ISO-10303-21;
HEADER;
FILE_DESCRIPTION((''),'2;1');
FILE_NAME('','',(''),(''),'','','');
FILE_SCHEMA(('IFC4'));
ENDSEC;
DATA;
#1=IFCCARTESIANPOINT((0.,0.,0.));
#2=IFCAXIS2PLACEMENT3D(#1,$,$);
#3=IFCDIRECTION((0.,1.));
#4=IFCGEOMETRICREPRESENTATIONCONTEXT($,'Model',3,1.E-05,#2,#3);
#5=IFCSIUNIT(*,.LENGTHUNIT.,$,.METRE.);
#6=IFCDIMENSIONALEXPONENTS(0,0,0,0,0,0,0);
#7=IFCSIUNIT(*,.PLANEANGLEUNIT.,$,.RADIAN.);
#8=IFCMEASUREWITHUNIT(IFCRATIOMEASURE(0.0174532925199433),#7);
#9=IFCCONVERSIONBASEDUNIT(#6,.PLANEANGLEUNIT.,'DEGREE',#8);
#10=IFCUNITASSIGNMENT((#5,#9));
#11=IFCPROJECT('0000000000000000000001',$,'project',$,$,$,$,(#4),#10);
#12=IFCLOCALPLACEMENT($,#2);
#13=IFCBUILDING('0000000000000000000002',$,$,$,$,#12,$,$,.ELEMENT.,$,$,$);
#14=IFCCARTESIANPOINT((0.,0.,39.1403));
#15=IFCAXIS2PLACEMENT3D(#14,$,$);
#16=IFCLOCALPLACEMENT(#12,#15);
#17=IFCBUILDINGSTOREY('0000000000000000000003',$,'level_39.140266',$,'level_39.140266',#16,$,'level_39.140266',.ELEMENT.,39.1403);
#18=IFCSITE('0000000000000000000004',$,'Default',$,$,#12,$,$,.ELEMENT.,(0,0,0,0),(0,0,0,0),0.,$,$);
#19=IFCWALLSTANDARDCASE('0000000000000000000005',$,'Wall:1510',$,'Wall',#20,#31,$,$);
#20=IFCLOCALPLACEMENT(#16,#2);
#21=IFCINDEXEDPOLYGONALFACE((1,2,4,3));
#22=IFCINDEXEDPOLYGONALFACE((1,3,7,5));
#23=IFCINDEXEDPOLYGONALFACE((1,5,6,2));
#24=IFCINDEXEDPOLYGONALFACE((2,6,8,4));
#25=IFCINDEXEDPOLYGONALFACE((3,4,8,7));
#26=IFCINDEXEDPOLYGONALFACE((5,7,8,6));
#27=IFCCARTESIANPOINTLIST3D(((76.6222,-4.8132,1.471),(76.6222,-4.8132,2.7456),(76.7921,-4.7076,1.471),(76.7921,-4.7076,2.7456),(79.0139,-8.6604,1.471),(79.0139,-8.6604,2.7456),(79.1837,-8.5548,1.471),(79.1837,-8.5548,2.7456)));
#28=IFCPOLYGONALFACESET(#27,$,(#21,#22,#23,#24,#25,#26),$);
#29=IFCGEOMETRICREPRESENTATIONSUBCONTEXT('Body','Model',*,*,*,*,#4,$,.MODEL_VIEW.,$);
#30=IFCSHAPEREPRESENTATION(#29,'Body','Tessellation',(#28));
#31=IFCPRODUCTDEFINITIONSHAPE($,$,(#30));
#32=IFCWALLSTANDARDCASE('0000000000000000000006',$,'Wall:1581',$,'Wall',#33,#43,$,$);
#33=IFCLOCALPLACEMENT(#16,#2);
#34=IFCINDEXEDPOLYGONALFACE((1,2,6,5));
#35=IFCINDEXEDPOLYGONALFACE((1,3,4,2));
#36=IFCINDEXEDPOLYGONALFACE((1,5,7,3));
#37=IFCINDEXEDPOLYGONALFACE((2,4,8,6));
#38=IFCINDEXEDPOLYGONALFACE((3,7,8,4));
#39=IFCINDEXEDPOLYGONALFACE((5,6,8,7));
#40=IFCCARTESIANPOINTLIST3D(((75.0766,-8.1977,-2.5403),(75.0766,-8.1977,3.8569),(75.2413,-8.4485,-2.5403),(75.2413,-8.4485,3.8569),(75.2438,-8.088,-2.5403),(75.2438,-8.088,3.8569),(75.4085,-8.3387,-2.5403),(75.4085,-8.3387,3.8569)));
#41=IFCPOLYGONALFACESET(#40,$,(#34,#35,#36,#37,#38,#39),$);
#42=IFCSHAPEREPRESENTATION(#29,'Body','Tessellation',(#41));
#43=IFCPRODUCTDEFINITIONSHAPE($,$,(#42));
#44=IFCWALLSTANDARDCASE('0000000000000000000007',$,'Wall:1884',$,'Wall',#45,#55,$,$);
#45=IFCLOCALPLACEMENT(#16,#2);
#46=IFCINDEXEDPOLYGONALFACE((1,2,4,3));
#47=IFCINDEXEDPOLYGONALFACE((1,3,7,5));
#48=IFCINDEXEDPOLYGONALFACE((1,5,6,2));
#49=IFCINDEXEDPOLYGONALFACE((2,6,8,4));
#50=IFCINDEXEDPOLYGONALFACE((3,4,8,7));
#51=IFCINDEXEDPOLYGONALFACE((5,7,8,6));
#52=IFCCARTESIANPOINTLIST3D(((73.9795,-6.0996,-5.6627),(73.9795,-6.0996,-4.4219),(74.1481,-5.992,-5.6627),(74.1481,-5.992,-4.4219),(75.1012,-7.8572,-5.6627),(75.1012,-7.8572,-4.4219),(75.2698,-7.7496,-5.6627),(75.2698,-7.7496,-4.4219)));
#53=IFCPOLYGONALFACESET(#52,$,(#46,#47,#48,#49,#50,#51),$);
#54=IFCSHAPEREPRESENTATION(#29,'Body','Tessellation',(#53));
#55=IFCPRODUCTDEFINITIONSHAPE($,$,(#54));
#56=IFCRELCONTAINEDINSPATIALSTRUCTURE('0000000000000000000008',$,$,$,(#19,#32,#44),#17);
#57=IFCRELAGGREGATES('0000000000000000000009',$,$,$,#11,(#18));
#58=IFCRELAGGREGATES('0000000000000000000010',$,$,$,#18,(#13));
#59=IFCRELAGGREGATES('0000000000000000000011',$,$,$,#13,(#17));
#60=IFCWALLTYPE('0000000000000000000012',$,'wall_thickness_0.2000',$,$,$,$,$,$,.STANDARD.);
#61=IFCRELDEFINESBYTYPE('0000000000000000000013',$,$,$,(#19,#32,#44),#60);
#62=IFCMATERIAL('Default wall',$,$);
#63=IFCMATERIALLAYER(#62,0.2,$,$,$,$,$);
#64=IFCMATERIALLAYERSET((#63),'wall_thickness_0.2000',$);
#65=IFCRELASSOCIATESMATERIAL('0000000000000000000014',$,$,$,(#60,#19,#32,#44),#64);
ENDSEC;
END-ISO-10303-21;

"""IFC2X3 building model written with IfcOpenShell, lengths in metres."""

from ifc_helpers import new_model, entity, si_unit, converted_unit, direction, frame, origin, place, context, subcontext, project, spatial, polyline, outline, extrude, material, layer, layer_set, layer_usage, type_object, element, save


model = new_model("IFC2X3")

# Units and contexts
model_context = context("Model", 3, precision=1e-05, world=origin(), true_north=direction((0.0, 1.0)))
body_context = subcontext(model_context, "Body", "Model", "MODEL_VIEW")
ifc_project = project(units=[si_unit("LENGTHUNIT", "METRE"), converted_unit("PLANEANGLEUNIT", "DEGREE", entity("IfcRatioMeasure", 0.0174532925199433), si_unit("PLANEANGLEUNIT", "RADIAN"), dimensions=[0, 0, 0, 0, 0, 0, 0])], contexts=[model_context])

# Site, building, storey
placement_1 = place(None, origin())
site = spatial("IfcSite", under=ifc_project, at=placement_1, Name="Default", CompositionType="ELEMENT", RefLatitude=(0, 0, 0, 0), RefLongitude=(0, 0, 0, 0), RefElevation=0.0)
building = spatial("IfcBuilding", under=site, at=placement_1, CompositionType="ELEMENT")
storey_placement = place(placement_1, frame((0.0, 0.0, 39.1403)))
storey = spatial("IfcBuildingStorey", under=building, at=storey_placement, Name="level_39.140266", ObjectType="level_39.140266", LongName="level_39.140266", CompositionType="ELEMENT", Elevation=39.1403)

# Walls
ifc_material = material(Name="Default wall")
ifc_layer = layer(ifc_material, 0.2)
ifc_layer_set = layer_set([ifc_layer], Name="wall_thickness_0.2000")
ifc_layer_usage = layer_usage(ifc_layer_set, "AXIS2", "POSITIVE", -0.1)
wall_type = type_object("IfcWallType", Name="wall_thickness_0.2000", PredefinedType="STANDARD", material=ifc_layer_set)
placement_2 = place(placement_1, frame((0.0, 0.0, 40.6113)))
wall_1_placement = place(placement_2, frame((76.7072, -4.7604, 0.0), z_axis=(0.0, 0.0, 1.0), x_axis=(0.527956, -0.849272, 0.0)))
element("IfcWallStandardCase", 1, at=wall_1_placement, inside=storey, type_object=wall_type, material=ifc_layer_usage, Name="Wall:1510", ObjectType="Wall", context=body_context, shape_type="SweptSolid", body=[
    extrude(outline(polyline([(4.53, -0.1), (4.53, 0.1), (0.0, 0.1), (0.0, -0.1), (4.53, -0.1)])), origin(), (0.0, 0.0, 1.0), 1.2746),
])
placement_3 = place(placement_1, frame((0.0, 0.0, 36.6)))
wall_2_placement = place(placement_3, frame((75.3249, -8.3936, 0.0), z_axis=(0.0, 0.0, 1.0), x_axis=(-0.548809, 0.835948, 0.0)))
element("IfcWallStandardCase", 2, at=wall_2_placement, inside=storey, type_object=wall_type, material=ifc_layer_usage, Name="Wall:1581", ObjectType="Wall", context=body_context, shape_type="SweptSolid", body=[
    extrude(outline(polyline([(0.3, -0.1), (0.3, 0.1), (0.0, 0.1), (0.0, -0.1), (0.3, -0.1)])), origin(), (0.0, 0.0, 1.0), 6.3972),
])
placement_4 = place(placement_1, frame((0.0, 0.0, 33.4776)))
wall_3_placement = place(placement_4, frame((74.0638, -6.0458, 0.0), z_axis=(0.0, 0.0, 1.0), x_axis=(0.537973, -0.842962, 0.0)))
element("IfcWallStandardCase", 3, at=wall_3_placement, inside=storey, type_object=wall_type, material=ifc_layer_usage, Name="Wall:1884", ObjectType="Wall", context=body_context, shape_type="SweptSolid", body=[
    extrude(outline(polyline([(2.085, -0.1), (2.085, 0.1), (0.0, 0.1), (0.0, -0.1), (2.085, -0.1)])), origin(), (0.0, 0.0, 1.0), 1.2408),
])

save(model, "model.ifc")
